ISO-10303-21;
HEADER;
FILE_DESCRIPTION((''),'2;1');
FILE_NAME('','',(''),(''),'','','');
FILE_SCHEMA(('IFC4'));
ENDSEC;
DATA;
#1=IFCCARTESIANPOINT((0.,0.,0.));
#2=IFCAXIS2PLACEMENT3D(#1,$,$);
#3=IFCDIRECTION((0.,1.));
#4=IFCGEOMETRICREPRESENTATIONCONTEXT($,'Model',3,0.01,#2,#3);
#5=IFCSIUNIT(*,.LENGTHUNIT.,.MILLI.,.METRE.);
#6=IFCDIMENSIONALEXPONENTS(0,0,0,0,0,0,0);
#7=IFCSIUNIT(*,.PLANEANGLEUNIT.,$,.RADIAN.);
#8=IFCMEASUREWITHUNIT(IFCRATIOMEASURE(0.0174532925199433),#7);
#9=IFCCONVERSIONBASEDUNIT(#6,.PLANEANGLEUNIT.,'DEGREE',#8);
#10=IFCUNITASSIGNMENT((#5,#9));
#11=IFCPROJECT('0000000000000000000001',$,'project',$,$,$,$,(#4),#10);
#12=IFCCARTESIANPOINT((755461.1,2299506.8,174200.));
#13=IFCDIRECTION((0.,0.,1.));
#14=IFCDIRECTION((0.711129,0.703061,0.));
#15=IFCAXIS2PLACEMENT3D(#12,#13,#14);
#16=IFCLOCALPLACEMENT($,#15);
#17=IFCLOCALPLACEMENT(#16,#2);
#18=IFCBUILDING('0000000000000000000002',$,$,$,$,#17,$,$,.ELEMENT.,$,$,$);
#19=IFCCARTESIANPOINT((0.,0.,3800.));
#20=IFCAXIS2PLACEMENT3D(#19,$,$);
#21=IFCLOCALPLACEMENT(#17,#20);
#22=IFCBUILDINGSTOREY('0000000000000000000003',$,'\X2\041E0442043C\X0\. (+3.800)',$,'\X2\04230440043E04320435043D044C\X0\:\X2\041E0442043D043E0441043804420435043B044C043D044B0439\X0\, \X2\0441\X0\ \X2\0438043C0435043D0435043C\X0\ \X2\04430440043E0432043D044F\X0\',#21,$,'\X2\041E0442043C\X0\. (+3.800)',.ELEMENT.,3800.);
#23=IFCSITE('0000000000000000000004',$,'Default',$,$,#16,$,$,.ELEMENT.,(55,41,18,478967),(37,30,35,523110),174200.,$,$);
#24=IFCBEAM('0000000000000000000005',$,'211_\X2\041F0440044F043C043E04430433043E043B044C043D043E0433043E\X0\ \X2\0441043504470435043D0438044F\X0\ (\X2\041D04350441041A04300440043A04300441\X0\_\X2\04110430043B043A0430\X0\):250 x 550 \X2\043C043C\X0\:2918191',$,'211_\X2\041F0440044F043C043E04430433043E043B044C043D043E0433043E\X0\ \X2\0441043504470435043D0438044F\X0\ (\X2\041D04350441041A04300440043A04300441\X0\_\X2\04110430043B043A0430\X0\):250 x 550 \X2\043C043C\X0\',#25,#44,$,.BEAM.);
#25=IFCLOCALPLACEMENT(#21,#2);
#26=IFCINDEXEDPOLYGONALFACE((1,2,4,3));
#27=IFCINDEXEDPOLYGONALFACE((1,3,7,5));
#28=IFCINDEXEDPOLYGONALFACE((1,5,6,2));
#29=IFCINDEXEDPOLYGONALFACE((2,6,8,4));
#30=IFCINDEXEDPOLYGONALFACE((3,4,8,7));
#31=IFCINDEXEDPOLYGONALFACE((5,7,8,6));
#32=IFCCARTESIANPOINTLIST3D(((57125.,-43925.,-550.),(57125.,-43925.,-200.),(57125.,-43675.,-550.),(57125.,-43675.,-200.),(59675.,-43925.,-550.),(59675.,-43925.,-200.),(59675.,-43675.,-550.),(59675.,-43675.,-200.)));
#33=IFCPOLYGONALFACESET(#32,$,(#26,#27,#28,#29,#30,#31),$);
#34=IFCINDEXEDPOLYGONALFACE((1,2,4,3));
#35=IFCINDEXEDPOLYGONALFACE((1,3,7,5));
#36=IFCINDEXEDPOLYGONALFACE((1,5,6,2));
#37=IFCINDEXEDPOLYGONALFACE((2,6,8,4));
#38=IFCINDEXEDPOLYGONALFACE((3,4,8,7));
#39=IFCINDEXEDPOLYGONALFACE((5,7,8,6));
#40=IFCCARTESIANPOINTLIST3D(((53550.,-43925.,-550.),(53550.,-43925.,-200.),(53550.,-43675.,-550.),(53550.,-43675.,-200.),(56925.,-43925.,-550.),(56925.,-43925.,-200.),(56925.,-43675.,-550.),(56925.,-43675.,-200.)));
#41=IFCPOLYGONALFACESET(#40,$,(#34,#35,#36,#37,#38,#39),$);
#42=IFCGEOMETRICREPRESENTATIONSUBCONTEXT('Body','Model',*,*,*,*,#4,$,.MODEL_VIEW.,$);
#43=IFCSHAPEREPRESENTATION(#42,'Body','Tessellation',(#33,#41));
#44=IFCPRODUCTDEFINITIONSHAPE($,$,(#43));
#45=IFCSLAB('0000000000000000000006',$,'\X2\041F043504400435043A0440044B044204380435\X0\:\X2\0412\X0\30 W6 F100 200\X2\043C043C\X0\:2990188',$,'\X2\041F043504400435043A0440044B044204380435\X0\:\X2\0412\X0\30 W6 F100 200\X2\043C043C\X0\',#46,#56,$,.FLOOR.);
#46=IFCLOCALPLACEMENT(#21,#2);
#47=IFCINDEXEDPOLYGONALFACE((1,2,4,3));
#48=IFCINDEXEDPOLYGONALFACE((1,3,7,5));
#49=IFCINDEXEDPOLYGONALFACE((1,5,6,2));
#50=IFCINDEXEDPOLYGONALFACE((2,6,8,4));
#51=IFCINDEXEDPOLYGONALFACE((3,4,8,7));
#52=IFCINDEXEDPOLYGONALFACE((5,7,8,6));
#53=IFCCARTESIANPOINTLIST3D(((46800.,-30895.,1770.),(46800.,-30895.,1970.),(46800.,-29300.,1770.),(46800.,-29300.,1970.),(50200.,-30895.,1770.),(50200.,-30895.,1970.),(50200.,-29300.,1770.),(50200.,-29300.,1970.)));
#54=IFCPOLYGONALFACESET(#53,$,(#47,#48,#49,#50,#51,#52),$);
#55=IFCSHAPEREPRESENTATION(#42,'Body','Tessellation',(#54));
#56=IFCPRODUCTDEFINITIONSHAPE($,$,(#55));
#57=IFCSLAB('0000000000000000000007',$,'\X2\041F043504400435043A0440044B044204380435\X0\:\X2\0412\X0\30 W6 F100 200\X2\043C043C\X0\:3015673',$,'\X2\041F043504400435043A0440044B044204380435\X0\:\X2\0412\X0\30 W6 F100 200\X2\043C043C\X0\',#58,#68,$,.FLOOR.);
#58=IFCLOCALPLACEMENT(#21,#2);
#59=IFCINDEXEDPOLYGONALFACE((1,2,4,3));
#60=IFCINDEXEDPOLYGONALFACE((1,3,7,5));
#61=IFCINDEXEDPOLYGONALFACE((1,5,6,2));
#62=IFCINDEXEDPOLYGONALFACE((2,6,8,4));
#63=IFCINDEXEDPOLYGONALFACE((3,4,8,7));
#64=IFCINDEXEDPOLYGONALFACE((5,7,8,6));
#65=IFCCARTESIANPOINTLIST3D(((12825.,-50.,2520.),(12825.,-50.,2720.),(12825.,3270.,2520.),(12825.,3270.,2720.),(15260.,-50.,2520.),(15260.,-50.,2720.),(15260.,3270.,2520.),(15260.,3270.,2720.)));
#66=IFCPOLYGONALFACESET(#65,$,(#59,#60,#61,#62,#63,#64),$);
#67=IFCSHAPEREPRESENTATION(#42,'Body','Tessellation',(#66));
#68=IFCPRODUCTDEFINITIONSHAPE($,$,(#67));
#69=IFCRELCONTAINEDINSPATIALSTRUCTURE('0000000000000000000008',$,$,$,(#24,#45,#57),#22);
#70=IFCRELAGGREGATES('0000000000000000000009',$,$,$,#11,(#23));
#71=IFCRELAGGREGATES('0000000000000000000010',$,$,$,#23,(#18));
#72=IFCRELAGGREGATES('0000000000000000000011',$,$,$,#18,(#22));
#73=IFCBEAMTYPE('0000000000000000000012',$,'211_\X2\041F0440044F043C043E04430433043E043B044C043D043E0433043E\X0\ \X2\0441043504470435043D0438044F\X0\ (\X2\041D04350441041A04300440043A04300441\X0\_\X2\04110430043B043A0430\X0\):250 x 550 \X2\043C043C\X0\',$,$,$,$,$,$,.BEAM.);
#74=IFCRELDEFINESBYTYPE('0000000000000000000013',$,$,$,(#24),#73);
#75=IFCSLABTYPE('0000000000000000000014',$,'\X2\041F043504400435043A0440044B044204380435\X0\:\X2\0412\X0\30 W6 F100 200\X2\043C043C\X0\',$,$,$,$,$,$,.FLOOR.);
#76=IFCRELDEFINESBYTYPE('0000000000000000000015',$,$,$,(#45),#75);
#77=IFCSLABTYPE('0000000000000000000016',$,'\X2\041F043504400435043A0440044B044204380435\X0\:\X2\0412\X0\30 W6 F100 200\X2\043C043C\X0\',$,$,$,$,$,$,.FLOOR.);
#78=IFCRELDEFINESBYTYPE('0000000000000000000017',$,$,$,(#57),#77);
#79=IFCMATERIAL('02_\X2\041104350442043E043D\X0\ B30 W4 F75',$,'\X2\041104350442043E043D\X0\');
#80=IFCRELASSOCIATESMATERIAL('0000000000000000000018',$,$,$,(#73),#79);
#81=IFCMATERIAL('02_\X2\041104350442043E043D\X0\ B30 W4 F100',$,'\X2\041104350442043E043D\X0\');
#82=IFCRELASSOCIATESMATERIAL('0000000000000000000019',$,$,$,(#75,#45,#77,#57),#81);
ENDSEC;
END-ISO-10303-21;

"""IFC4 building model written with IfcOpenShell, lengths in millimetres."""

from ifc_helpers import new_model, entity, si_unit, converted_unit, direction, frame, origin, place, context, subcontext, project, spatial, indexed_curve, outline, extrude, source, transform, mapped, material, type_object, type_shapes, element, save


model = new_model("IFC4")

# Units and contexts
model_context = context("Model", 3, precision=0.01, world=origin(), true_north=direction((0.0, 1.0)))
body_context = subcontext(model_context, "Body", "Model", "MODEL_VIEW")
ifc_project = project(units=[si_unit("LENGTHUNIT", "METRE", prefix="MILLI"), converted_unit("PLANEANGLEUNIT", "DEGREE", entity("IfcRatioMeasure", 0.0174532925199433), si_unit("PLANEANGLEUNIT", "RADIAN"), dimensions=[0, 0, 0, 0, 0, 0, 0])], contexts=[model_context])

# Site, building, storey
site_placement = place(None, frame((755461.1, 2299506.8, 174200.0), z_axis=(0.0, 0.0, 1.0), x_axis=(0.711129, 0.703061, 0.0)))
site = spatial("IfcSite", under=ifc_project, at=site_placement, Name="Default", CompositionType="ELEMENT", RefLatitude=(55, 41, 18, 478967), RefLongitude=(37, 30, 35, 523110), RefElevation=174200.0)
building_placement = place(site_placement, origin())
building = spatial("IfcBuilding", under=site, at=building_placement, CompositionType="ELEMENT")
storey_placement = place(building_placement, frame((0.0, 0.0, 3800.0)))
storey = spatial("IfcBuildingStorey", under=building, at=storey_placement, Name="Отм. (+3.800)", ObjectType="Уровень:Относительный, с именем уровня", LongName="Отм. (+3.800)", CompositionType="ELEMENT", Elevation=3800.0)

# Beam
ifc_material_1 = material(Name="02_Бетон B30 W4 F75", Category="Бетон")
beam_type = type_object("IfcBeamType", Name="211_Прямоугольного сечения (НесКаркас_Балка):250 x 550 мм", PredefinedType="BEAM", material=ifc_material_1)
shared_shape_1 = source(origin(), body_context, "Body", "SweptSolid", [
    extrude(outline(indexed_curve([(-175.0, -125.0), (175.0, -125.0), (175.0, 125.0), (-175.0, 125.0), (-175.0, -125.0)], self_intersect=False)), frame((57125.0, -43800.0, 3425.0), z_axis=(1.0, 0.0, 0.0), x_axis=(0.0, 0.0, -1.0)), (0.0, 0.0, 1.0), 2550.0),
    extrude(outline(indexed_curve([(-175.0, -125.0), (175.0, -125.0), (175.0, 125.0), (-175.0, 125.0), (-175.0, -125.0)], self_intersect=False)), frame((53550.0, -43800.0, 3425.0), z_axis=(1.0, 0.0, 0.0), x_axis=(0.0, 0.0, -1.0)), (0.0, 0.0, 1.0), 3375.0),
])
type_shapes(beam_type, [shared_shape_1])
beam_placement = place(storey_placement, frame((0.0, 0.0, -3800.0)))
element("IfcBeam", 1, at=beam_placement, inside=storey, type_object=beam_type, Name="211_Прямоугольного сечения (НесКаркас_Балка):250 x 550 мм:2918191", ObjectType="211_Прямоугольного сечения (НесКаркас_Балка):250 x 550 мм", PredefinedType="BEAM", context=body_context, shape_type="MappedRepresentation", body=[
    mapped(shared_shape_1, transform((0.0, 0.0, 0.0), scale=1.0)),
])

# Slabs
ifc_material_2 = material(Name="02_Бетон B30 W4 F100", Category="Бетон")
slab_type_1 = type_object("IfcSlabType", Name="Перекрытие:В30 W6 F100 200мм", PredefinedType="FLOOR", material=ifc_material_2)
slab_1_placement = place(storey_placement, origin())
element("IfcSlab", 2, at=slab_1_placement, inside=storey, type_object=slab_type_1, material=ifc_material_2, Name="Перекрытие:В30 W6 F100 200мм:2990188", ObjectType="Перекрытие:В30 W6 F100 200мм", PredefinedType="FLOOR", context=body_context, shape_type="SweptSolid", body=[
    extrude(outline(indexed_curve([(-797.5, -1700.0), (797.5, -1700.0), (797.5, 1700.0), (-797.5, 1700.0), (-797.5, -1700.0)], self_intersect=False)), frame((48500.0, -30097.5, 1970.0), z_axis=(0.0, 0.0, -1.0), x_axis=(0.0, 1.0, 0.0)), (0.0, 0.0, 1.0), 200.0),
])
slab_type_2 = type_object("IfcSlabType", Name="Перекрытие:В30 W6 F100 200мм", PredefinedType="FLOOR", material=ifc_material_2)
slab_2_placement = place(storey_placement, origin())
element("IfcSlab", 3, at=slab_2_placement, inside=storey, type_object=slab_type_2, material=ifc_material_2, Name="Перекрытие:В30 W6 F100 200мм:3015673", ObjectType="Перекрытие:В30 W6 F100 200мм", PredefinedType="FLOOR", context=body_context, shape_type="SweptSolid", body=[
    extrude(outline(indexed_curve([(-1660.0, -1217.5), (1660.0, -1217.5), (1660.0, 1217.5), (-1660.0, 1217.5), (-1660.0, -1217.5)], self_intersect=False)), frame((14042.5, 1610.0, 2720.0), z_axis=(0.0, 0.0, -1.0), x_axis=(0.0, 1.0, 0.0)), (0.0, 0.0, 1.0), 200.0),
])

save(model, "model.ifc")
